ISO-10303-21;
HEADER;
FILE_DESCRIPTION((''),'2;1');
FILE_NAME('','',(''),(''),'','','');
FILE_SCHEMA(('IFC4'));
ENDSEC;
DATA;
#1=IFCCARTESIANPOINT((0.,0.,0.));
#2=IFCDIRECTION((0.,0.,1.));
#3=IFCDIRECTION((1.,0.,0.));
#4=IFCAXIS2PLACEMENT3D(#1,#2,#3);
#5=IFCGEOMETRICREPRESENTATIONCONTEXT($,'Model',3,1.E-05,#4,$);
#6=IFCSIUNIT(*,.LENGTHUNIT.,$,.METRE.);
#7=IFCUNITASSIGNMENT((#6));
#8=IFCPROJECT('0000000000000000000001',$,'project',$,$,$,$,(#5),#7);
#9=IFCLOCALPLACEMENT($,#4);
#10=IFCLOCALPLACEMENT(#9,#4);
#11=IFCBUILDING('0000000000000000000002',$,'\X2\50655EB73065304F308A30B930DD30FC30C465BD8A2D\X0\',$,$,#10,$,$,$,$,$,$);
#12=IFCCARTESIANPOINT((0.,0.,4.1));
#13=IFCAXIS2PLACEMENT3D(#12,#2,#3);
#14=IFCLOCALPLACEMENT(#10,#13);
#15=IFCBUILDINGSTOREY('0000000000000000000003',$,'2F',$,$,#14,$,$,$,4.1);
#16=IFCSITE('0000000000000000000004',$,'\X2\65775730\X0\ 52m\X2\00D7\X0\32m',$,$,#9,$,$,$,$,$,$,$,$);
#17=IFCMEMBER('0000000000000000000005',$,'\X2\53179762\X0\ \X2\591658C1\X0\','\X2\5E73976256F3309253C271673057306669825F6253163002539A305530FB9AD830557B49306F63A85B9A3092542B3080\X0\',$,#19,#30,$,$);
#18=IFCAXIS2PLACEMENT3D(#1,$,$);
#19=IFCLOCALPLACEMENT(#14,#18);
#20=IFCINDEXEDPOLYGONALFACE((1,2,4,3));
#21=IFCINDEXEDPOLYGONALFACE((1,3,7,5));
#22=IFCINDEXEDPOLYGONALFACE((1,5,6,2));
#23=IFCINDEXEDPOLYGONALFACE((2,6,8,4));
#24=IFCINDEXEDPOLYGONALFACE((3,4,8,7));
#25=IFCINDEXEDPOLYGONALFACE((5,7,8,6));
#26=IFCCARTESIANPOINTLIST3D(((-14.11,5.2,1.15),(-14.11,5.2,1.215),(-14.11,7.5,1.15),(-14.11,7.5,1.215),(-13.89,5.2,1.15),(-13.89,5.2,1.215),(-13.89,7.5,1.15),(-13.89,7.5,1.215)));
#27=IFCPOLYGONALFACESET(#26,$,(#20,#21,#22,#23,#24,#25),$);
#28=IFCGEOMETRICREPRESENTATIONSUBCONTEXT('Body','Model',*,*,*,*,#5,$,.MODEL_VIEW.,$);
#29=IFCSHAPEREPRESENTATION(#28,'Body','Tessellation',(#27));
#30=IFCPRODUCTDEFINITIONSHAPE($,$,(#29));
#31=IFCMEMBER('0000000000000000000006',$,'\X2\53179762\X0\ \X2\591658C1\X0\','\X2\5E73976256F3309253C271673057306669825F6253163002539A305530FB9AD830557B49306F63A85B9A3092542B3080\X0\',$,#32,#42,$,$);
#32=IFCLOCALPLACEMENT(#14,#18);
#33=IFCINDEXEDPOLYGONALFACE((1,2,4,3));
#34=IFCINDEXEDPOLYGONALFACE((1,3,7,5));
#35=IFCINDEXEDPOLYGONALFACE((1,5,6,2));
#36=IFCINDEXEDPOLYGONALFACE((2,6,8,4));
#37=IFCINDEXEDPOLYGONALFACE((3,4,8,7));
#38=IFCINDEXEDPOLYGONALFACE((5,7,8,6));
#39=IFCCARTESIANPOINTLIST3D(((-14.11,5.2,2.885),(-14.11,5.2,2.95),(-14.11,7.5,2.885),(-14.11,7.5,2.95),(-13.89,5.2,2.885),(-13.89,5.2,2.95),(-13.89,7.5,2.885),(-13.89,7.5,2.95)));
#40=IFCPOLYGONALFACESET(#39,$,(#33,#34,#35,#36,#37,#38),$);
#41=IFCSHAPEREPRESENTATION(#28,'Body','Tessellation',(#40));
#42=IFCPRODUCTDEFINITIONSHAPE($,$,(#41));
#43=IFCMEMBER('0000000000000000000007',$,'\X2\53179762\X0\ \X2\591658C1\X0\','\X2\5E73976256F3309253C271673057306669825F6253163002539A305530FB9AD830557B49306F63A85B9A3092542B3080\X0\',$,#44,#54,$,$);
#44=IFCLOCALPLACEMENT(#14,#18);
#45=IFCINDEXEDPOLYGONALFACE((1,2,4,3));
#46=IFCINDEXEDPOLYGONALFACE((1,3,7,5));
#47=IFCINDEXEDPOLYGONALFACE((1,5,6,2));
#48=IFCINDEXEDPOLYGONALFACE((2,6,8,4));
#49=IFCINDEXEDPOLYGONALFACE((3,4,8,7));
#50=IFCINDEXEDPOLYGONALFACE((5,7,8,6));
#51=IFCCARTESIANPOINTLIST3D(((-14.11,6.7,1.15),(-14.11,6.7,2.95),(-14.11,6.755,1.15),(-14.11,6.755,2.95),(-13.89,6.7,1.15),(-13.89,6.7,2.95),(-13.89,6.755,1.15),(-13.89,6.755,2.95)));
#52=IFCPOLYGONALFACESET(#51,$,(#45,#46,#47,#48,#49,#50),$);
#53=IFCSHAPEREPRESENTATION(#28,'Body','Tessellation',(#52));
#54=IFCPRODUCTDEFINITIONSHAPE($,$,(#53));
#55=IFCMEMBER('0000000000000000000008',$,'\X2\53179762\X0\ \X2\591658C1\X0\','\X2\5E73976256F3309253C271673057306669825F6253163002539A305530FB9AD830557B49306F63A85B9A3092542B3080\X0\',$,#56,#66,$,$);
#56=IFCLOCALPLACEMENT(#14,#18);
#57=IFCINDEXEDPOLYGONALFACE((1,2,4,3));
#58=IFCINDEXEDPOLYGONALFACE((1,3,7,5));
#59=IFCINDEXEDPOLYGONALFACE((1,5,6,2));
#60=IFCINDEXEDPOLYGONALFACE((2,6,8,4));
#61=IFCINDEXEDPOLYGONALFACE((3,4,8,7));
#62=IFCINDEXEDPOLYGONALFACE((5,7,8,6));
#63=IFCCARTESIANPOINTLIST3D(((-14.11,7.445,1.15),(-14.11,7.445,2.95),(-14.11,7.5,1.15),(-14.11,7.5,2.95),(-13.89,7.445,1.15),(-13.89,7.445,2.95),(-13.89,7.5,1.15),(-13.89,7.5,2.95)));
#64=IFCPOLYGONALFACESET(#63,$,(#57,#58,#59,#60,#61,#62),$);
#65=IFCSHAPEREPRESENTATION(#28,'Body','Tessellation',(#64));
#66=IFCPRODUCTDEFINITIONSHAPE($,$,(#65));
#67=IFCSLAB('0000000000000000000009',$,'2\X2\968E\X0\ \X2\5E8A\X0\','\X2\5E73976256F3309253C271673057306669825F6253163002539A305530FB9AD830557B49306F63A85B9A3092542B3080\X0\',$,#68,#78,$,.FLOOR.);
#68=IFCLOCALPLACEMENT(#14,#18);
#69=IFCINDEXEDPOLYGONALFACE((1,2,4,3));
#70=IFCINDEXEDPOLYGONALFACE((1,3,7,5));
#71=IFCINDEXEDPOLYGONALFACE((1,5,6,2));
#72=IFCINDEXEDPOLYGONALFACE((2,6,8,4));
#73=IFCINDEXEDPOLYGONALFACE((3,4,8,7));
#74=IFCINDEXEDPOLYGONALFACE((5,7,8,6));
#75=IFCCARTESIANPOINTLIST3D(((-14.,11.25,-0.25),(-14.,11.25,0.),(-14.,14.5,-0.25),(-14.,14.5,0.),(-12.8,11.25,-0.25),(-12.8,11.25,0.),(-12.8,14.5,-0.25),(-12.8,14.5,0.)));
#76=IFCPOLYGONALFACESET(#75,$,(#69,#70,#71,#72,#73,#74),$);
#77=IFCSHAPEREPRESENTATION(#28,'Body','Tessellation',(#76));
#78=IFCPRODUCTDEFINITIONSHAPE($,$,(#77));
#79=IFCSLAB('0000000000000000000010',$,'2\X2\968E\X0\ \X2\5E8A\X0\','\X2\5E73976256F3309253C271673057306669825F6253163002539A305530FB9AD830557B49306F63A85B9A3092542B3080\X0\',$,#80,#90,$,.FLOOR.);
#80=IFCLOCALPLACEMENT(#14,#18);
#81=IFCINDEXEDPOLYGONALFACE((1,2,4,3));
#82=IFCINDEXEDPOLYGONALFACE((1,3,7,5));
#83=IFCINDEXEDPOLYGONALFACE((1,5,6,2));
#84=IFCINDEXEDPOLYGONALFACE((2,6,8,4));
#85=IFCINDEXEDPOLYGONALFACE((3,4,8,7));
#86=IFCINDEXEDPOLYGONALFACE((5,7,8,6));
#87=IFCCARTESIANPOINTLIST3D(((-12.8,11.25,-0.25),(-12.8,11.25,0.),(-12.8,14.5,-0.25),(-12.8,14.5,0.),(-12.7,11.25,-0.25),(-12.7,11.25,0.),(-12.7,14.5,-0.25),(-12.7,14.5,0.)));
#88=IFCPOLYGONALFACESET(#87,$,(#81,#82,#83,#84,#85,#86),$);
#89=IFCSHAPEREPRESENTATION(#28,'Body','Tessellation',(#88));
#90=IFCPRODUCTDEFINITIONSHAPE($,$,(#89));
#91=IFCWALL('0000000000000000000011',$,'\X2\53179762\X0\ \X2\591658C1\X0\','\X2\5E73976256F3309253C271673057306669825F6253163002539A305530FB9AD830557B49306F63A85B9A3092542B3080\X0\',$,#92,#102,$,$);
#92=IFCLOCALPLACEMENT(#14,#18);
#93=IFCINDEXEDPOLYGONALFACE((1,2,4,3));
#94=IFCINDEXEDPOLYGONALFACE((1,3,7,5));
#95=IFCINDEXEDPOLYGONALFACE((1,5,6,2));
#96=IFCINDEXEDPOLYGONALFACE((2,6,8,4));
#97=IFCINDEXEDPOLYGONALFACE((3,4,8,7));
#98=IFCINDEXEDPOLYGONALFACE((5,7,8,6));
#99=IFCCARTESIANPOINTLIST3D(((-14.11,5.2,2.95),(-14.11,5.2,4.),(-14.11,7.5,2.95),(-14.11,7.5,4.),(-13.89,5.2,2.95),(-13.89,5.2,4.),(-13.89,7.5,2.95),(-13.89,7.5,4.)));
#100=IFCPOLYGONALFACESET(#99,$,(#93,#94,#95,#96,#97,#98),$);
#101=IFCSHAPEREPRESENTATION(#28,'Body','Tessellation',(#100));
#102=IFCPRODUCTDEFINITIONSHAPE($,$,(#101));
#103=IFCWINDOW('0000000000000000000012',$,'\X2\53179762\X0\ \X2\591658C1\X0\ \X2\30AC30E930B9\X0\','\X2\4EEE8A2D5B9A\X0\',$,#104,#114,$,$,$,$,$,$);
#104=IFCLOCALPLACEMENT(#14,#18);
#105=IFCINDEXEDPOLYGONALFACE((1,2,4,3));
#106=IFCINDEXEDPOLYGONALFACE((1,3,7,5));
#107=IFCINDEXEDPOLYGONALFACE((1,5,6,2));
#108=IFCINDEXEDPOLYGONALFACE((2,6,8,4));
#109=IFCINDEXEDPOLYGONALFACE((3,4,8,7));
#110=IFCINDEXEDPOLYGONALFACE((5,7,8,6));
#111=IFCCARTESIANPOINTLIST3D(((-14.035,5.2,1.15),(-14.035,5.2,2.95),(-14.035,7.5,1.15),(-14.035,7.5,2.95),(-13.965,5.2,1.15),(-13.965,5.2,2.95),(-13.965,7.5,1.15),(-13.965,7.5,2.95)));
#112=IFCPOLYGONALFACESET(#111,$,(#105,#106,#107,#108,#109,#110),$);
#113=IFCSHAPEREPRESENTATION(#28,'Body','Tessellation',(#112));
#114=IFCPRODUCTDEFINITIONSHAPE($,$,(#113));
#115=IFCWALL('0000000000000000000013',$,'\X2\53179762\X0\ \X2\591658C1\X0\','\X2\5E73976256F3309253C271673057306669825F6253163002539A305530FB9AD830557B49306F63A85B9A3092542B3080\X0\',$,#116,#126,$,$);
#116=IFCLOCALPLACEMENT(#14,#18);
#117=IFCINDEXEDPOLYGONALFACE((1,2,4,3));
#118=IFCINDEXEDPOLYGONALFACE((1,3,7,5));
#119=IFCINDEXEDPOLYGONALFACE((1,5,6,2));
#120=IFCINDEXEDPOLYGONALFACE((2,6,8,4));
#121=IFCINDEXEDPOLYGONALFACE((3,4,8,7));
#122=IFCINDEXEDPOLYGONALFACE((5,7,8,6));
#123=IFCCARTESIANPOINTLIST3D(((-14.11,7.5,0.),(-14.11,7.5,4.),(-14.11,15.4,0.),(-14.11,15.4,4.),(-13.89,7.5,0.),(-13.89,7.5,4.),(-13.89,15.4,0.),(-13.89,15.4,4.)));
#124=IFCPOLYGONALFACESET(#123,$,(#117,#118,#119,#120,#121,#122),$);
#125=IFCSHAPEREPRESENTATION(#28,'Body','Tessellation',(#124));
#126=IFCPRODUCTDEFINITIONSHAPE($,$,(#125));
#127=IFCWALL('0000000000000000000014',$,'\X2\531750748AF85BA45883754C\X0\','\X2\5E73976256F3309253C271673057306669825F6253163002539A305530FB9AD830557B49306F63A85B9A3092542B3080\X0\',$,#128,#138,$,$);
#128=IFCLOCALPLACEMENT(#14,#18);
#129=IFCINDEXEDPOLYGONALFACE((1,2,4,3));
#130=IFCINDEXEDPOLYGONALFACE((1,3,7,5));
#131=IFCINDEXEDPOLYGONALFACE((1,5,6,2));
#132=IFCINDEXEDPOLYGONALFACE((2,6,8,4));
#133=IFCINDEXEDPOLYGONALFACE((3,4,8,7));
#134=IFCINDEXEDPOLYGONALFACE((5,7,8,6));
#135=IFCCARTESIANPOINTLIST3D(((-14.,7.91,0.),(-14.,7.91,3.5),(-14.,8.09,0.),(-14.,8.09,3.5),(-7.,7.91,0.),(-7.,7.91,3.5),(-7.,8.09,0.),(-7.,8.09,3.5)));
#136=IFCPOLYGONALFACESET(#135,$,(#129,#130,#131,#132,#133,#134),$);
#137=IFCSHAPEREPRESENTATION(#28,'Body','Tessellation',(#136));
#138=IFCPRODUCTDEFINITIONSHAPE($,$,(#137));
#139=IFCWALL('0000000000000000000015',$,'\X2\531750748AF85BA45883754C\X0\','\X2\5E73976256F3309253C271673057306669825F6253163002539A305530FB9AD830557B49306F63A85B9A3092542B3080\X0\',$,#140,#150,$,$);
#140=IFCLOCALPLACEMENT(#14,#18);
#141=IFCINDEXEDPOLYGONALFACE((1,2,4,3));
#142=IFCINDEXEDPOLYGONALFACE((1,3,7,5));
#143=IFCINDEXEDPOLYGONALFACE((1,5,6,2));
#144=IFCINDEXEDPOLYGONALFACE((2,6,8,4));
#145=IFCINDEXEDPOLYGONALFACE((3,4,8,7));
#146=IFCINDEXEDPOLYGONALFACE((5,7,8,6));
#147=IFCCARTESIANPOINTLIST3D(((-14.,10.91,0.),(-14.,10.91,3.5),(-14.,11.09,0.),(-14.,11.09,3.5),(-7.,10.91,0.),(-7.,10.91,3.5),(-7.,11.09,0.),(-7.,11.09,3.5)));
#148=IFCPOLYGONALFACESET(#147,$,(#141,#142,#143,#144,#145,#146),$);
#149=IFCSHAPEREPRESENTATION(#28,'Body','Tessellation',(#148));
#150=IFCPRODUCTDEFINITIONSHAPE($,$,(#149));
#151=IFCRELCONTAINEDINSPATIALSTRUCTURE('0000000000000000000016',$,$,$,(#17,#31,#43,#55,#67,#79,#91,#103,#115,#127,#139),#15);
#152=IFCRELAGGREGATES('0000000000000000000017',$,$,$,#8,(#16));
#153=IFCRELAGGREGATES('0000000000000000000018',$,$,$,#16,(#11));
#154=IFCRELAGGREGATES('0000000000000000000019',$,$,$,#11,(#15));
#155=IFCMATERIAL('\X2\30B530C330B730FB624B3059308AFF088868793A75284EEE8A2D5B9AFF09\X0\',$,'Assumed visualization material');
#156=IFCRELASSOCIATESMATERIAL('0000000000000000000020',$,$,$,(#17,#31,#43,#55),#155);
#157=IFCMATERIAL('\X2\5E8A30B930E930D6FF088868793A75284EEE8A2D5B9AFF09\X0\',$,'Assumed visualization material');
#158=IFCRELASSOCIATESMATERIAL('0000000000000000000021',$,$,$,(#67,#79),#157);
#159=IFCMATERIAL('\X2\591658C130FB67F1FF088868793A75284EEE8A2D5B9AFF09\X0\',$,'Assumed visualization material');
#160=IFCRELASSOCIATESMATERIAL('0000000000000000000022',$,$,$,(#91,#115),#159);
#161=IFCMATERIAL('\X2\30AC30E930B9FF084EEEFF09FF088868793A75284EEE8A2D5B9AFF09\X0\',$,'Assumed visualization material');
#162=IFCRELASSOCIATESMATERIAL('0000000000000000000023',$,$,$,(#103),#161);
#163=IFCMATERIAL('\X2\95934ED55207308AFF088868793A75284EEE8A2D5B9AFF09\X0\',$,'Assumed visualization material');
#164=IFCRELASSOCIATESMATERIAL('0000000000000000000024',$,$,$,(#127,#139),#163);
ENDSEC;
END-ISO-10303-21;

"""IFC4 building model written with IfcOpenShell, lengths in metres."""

from ifc_helpers import new_model, si_unit, frame, origin_with_axes, place, context, subcontext, project, spatial, rectangle, extrude, material, element, save


model = new_model("IFC4")

# Units and contexts
model_context = context("Model", 3, precision=1e-05, world=origin_with_axes())
body_context = subcontext(model_context, "Body", "Model", "MODEL_VIEW")
ifc_project = project(units=[si_unit("LENGTHUNIT", "METRE")], contexts=[model_context])

# Site, building, storey
site_placement = place(None, origin_with_axes())
site = spatial("IfcSite", under=ifc_project, at=site_placement, Name="敷地 52m×32m")
building_placement = place(site_placement, origin_with_axes())
building = spatial("IfcBuilding", under=site, at=building_placement, Name="健康づくりスポーツ施設")
storey_placement = place(building_placement, frame((0.0, 0.0, 4.1), z_axis=(0.0, 0.0, 1.0), x_axis=(1.0, 0.0, 0.0)))
storey = spatial("IfcBuildingStorey", under=building, at=storey_placement, Name="2F", Elevation=4.1)

# Members
ifc_material_1 = material(Name="サッシ・手すり（表示用仮設定）", Category="Assumed visualization material")
for number, where, z_axis, x_axis, name in (
    (1, (-14.0, 6.35, 1.15), (0.0, 0.0, 1.0), (1.0, 0.0, 0.0), "北面 外壁"),
    (2, (-14.0, 6.35, 2.885), (0.0, 0.0, 1.0), (1.0, 0.0, 0.0), "北面 外壁"),
):
    element("IfcMember", number, at=place(storey_placement, frame(where, z_axis=z_axis, x_axis=x_axis)), inside=storey, material=ifc_material_1, Name=name, Description="平面図を参照して概形化。厚さ・高さ等は推定を含む", context=body_context, shape_type="SweptSolid", body=[
        extrude(rectangle(XDim=0.22, YDim=2.3), origin_with_axes(), (0.0, 0.0, 1.0), 0.065),
    ])
for number, where, z_axis, x_axis, name in (
    (3, (-14.0, 6.7275, 1.15), (0.0, 0.0, 1.0), (1.0, 0.0, 0.0), "北面 外壁"),
    (4, (-14.0, 7.4725, 1.15), (0.0, 0.0, 1.0), (1.0, 0.0, 0.0), "北面 外壁"),
):
    element("IfcMember", number, at=place(storey_placement, frame(where, z_axis=z_axis, x_axis=x_axis)), inside=storey, material=ifc_material_1, Name=name, Description="平面図を参照して概形化。厚さ・高さ等は推定を含む", context=body_context, shape_type="SweptSolid", body=[
        extrude(rectangle(XDim=0.22, YDim=0.055), origin_with_axes(), (0.0, 0.0, 1.0), 1.8),
    ])

# Slabs
ifc_material_2 = material(Name="床スラブ（表示用仮設定）", Category="Assumed visualization material")
slab_1_placement = place(storey_placement, frame((-13.4, 12.875, -0.25), z_axis=(0.0, 0.0, 1.0), x_axis=(1.0, 0.0, 0.0)))
element("IfcSlab", 5, at=slab_1_placement, inside=storey, material=ifc_material_2, Name="2階 床", Description="平面図を参照して概形化。厚さ・高さ等は推定を含む", PredefinedType="FLOOR", context=body_context, shape_type="SweptSolid", body=[
    extrude(rectangle(XDim=1.2, YDim=3.25), origin_with_axes(), (0.0, 0.0, 1.0), 0.25),
])
slab_2_placement = place(storey_placement, frame((-12.75, 12.875, -0.25), z_axis=(0.0, 0.0, 1.0), x_axis=(1.0, 0.0, 0.0)))
element("IfcSlab", 6, at=slab_2_placement, inside=storey, material=ifc_material_2, Name="2階 床", Description="平面図を参照して概形化。厚さ・高さ等は推定を含む", PredefinedType="FLOOR", context=body_context, shape_type="SweptSolid", body=[
    extrude(rectangle(XDim=0.1, YDim=3.25), origin_with_axes(), (0.0, 0.0, 1.0), 0.25),
])

# Wall
ifc_material_3 = material(Name="外壁・柱（表示用仮設定）", Category="Assumed visualization material")
wall_1_placement = place(storey_placement, frame((-14.0, 6.35, 2.95), z_axis=(0.0, 0.0, 1.0), x_axis=(1.0, 0.0, 0.0)))
element("IfcWall", 7, at=wall_1_placement, inside=storey, material=ifc_material_3, Name="北面 外壁", Description="平面図を参照して概形化。厚さ・高さ等は推定を含む", context=body_context, shape_type="SweptSolid", body=[
    extrude(rectangle(XDim=0.22, YDim=2.3), origin_with_axes(), (0.0, 0.0, 1.0), 1.05),
])

# Window
ifc_material_4 = material(Name="ガラス（仮）（表示用仮設定）", Category="Assumed visualization material")
window_placement = place(storey_placement, frame((-14.0, 6.35, 1.15), z_axis=(0.0, 0.0, 1.0), x_axis=(1.0, 0.0, 0.0)))
element("IfcWindow", 8, at=window_placement, inside=storey, material=ifc_material_4, Name="北面 外壁 ガラス", Description="仮設定", context=body_context, shape_type="SweptSolid", body=[
    extrude(rectangle(XDim=0.07, YDim=2.3), origin_with_axes(), (0.0, 0.0, 1.0), 1.8),
])

# Walls
wall_2_placement = place(storey_placement, frame((-14.0, 11.45, 0.0), z_axis=(0.0, 0.0, 1.0), x_axis=(1.0, 0.0, 0.0)))
element("IfcWall", 9, at=wall_2_placement, inside=storey, material=ifc_material_3, Name="北面 外壁", Description="平面図を参照して概形化。厚さ・高さ等は推定を含む", context=body_context, shape_type="SweptSolid", body=[
    extrude(rectangle(XDim=0.22, YDim=7.9), origin_with_axes(), (0.0, 0.0, 1.0), 4.0),
])
ifc_material_5 = material(Name="間仕切り（表示用仮設定）", Category="Assumed visualization material")
for number, where, z_axis, x_axis, name in (
    (10, (-10.5, 8.0, 0.0), (0.0, 0.0, 1.0), (1.0, 0.0, 0.0), "北側諸室境界"),
    (11, (-10.5, 11.0, 0.0), (0.0, 0.0, 1.0), (1.0, 0.0, 0.0), "北側諸室境界"),
):
    element("IfcWall", number, at=place(storey_placement, frame(where, z_axis=z_axis, x_axis=x_axis)), inside=storey, material=ifc_material_5, Name=name, Description="平面図を参照して概形化。厚さ・高さ等は推定を含む", context=body_context, shape_type="SweptSolid", body=[
        extrude(rectangle(XDim=7.0, YDim=0.18), origin_with_axes(), (0.0, 0.0, 1.0), 3.5),
    ])

save(model, "model.ifc")
